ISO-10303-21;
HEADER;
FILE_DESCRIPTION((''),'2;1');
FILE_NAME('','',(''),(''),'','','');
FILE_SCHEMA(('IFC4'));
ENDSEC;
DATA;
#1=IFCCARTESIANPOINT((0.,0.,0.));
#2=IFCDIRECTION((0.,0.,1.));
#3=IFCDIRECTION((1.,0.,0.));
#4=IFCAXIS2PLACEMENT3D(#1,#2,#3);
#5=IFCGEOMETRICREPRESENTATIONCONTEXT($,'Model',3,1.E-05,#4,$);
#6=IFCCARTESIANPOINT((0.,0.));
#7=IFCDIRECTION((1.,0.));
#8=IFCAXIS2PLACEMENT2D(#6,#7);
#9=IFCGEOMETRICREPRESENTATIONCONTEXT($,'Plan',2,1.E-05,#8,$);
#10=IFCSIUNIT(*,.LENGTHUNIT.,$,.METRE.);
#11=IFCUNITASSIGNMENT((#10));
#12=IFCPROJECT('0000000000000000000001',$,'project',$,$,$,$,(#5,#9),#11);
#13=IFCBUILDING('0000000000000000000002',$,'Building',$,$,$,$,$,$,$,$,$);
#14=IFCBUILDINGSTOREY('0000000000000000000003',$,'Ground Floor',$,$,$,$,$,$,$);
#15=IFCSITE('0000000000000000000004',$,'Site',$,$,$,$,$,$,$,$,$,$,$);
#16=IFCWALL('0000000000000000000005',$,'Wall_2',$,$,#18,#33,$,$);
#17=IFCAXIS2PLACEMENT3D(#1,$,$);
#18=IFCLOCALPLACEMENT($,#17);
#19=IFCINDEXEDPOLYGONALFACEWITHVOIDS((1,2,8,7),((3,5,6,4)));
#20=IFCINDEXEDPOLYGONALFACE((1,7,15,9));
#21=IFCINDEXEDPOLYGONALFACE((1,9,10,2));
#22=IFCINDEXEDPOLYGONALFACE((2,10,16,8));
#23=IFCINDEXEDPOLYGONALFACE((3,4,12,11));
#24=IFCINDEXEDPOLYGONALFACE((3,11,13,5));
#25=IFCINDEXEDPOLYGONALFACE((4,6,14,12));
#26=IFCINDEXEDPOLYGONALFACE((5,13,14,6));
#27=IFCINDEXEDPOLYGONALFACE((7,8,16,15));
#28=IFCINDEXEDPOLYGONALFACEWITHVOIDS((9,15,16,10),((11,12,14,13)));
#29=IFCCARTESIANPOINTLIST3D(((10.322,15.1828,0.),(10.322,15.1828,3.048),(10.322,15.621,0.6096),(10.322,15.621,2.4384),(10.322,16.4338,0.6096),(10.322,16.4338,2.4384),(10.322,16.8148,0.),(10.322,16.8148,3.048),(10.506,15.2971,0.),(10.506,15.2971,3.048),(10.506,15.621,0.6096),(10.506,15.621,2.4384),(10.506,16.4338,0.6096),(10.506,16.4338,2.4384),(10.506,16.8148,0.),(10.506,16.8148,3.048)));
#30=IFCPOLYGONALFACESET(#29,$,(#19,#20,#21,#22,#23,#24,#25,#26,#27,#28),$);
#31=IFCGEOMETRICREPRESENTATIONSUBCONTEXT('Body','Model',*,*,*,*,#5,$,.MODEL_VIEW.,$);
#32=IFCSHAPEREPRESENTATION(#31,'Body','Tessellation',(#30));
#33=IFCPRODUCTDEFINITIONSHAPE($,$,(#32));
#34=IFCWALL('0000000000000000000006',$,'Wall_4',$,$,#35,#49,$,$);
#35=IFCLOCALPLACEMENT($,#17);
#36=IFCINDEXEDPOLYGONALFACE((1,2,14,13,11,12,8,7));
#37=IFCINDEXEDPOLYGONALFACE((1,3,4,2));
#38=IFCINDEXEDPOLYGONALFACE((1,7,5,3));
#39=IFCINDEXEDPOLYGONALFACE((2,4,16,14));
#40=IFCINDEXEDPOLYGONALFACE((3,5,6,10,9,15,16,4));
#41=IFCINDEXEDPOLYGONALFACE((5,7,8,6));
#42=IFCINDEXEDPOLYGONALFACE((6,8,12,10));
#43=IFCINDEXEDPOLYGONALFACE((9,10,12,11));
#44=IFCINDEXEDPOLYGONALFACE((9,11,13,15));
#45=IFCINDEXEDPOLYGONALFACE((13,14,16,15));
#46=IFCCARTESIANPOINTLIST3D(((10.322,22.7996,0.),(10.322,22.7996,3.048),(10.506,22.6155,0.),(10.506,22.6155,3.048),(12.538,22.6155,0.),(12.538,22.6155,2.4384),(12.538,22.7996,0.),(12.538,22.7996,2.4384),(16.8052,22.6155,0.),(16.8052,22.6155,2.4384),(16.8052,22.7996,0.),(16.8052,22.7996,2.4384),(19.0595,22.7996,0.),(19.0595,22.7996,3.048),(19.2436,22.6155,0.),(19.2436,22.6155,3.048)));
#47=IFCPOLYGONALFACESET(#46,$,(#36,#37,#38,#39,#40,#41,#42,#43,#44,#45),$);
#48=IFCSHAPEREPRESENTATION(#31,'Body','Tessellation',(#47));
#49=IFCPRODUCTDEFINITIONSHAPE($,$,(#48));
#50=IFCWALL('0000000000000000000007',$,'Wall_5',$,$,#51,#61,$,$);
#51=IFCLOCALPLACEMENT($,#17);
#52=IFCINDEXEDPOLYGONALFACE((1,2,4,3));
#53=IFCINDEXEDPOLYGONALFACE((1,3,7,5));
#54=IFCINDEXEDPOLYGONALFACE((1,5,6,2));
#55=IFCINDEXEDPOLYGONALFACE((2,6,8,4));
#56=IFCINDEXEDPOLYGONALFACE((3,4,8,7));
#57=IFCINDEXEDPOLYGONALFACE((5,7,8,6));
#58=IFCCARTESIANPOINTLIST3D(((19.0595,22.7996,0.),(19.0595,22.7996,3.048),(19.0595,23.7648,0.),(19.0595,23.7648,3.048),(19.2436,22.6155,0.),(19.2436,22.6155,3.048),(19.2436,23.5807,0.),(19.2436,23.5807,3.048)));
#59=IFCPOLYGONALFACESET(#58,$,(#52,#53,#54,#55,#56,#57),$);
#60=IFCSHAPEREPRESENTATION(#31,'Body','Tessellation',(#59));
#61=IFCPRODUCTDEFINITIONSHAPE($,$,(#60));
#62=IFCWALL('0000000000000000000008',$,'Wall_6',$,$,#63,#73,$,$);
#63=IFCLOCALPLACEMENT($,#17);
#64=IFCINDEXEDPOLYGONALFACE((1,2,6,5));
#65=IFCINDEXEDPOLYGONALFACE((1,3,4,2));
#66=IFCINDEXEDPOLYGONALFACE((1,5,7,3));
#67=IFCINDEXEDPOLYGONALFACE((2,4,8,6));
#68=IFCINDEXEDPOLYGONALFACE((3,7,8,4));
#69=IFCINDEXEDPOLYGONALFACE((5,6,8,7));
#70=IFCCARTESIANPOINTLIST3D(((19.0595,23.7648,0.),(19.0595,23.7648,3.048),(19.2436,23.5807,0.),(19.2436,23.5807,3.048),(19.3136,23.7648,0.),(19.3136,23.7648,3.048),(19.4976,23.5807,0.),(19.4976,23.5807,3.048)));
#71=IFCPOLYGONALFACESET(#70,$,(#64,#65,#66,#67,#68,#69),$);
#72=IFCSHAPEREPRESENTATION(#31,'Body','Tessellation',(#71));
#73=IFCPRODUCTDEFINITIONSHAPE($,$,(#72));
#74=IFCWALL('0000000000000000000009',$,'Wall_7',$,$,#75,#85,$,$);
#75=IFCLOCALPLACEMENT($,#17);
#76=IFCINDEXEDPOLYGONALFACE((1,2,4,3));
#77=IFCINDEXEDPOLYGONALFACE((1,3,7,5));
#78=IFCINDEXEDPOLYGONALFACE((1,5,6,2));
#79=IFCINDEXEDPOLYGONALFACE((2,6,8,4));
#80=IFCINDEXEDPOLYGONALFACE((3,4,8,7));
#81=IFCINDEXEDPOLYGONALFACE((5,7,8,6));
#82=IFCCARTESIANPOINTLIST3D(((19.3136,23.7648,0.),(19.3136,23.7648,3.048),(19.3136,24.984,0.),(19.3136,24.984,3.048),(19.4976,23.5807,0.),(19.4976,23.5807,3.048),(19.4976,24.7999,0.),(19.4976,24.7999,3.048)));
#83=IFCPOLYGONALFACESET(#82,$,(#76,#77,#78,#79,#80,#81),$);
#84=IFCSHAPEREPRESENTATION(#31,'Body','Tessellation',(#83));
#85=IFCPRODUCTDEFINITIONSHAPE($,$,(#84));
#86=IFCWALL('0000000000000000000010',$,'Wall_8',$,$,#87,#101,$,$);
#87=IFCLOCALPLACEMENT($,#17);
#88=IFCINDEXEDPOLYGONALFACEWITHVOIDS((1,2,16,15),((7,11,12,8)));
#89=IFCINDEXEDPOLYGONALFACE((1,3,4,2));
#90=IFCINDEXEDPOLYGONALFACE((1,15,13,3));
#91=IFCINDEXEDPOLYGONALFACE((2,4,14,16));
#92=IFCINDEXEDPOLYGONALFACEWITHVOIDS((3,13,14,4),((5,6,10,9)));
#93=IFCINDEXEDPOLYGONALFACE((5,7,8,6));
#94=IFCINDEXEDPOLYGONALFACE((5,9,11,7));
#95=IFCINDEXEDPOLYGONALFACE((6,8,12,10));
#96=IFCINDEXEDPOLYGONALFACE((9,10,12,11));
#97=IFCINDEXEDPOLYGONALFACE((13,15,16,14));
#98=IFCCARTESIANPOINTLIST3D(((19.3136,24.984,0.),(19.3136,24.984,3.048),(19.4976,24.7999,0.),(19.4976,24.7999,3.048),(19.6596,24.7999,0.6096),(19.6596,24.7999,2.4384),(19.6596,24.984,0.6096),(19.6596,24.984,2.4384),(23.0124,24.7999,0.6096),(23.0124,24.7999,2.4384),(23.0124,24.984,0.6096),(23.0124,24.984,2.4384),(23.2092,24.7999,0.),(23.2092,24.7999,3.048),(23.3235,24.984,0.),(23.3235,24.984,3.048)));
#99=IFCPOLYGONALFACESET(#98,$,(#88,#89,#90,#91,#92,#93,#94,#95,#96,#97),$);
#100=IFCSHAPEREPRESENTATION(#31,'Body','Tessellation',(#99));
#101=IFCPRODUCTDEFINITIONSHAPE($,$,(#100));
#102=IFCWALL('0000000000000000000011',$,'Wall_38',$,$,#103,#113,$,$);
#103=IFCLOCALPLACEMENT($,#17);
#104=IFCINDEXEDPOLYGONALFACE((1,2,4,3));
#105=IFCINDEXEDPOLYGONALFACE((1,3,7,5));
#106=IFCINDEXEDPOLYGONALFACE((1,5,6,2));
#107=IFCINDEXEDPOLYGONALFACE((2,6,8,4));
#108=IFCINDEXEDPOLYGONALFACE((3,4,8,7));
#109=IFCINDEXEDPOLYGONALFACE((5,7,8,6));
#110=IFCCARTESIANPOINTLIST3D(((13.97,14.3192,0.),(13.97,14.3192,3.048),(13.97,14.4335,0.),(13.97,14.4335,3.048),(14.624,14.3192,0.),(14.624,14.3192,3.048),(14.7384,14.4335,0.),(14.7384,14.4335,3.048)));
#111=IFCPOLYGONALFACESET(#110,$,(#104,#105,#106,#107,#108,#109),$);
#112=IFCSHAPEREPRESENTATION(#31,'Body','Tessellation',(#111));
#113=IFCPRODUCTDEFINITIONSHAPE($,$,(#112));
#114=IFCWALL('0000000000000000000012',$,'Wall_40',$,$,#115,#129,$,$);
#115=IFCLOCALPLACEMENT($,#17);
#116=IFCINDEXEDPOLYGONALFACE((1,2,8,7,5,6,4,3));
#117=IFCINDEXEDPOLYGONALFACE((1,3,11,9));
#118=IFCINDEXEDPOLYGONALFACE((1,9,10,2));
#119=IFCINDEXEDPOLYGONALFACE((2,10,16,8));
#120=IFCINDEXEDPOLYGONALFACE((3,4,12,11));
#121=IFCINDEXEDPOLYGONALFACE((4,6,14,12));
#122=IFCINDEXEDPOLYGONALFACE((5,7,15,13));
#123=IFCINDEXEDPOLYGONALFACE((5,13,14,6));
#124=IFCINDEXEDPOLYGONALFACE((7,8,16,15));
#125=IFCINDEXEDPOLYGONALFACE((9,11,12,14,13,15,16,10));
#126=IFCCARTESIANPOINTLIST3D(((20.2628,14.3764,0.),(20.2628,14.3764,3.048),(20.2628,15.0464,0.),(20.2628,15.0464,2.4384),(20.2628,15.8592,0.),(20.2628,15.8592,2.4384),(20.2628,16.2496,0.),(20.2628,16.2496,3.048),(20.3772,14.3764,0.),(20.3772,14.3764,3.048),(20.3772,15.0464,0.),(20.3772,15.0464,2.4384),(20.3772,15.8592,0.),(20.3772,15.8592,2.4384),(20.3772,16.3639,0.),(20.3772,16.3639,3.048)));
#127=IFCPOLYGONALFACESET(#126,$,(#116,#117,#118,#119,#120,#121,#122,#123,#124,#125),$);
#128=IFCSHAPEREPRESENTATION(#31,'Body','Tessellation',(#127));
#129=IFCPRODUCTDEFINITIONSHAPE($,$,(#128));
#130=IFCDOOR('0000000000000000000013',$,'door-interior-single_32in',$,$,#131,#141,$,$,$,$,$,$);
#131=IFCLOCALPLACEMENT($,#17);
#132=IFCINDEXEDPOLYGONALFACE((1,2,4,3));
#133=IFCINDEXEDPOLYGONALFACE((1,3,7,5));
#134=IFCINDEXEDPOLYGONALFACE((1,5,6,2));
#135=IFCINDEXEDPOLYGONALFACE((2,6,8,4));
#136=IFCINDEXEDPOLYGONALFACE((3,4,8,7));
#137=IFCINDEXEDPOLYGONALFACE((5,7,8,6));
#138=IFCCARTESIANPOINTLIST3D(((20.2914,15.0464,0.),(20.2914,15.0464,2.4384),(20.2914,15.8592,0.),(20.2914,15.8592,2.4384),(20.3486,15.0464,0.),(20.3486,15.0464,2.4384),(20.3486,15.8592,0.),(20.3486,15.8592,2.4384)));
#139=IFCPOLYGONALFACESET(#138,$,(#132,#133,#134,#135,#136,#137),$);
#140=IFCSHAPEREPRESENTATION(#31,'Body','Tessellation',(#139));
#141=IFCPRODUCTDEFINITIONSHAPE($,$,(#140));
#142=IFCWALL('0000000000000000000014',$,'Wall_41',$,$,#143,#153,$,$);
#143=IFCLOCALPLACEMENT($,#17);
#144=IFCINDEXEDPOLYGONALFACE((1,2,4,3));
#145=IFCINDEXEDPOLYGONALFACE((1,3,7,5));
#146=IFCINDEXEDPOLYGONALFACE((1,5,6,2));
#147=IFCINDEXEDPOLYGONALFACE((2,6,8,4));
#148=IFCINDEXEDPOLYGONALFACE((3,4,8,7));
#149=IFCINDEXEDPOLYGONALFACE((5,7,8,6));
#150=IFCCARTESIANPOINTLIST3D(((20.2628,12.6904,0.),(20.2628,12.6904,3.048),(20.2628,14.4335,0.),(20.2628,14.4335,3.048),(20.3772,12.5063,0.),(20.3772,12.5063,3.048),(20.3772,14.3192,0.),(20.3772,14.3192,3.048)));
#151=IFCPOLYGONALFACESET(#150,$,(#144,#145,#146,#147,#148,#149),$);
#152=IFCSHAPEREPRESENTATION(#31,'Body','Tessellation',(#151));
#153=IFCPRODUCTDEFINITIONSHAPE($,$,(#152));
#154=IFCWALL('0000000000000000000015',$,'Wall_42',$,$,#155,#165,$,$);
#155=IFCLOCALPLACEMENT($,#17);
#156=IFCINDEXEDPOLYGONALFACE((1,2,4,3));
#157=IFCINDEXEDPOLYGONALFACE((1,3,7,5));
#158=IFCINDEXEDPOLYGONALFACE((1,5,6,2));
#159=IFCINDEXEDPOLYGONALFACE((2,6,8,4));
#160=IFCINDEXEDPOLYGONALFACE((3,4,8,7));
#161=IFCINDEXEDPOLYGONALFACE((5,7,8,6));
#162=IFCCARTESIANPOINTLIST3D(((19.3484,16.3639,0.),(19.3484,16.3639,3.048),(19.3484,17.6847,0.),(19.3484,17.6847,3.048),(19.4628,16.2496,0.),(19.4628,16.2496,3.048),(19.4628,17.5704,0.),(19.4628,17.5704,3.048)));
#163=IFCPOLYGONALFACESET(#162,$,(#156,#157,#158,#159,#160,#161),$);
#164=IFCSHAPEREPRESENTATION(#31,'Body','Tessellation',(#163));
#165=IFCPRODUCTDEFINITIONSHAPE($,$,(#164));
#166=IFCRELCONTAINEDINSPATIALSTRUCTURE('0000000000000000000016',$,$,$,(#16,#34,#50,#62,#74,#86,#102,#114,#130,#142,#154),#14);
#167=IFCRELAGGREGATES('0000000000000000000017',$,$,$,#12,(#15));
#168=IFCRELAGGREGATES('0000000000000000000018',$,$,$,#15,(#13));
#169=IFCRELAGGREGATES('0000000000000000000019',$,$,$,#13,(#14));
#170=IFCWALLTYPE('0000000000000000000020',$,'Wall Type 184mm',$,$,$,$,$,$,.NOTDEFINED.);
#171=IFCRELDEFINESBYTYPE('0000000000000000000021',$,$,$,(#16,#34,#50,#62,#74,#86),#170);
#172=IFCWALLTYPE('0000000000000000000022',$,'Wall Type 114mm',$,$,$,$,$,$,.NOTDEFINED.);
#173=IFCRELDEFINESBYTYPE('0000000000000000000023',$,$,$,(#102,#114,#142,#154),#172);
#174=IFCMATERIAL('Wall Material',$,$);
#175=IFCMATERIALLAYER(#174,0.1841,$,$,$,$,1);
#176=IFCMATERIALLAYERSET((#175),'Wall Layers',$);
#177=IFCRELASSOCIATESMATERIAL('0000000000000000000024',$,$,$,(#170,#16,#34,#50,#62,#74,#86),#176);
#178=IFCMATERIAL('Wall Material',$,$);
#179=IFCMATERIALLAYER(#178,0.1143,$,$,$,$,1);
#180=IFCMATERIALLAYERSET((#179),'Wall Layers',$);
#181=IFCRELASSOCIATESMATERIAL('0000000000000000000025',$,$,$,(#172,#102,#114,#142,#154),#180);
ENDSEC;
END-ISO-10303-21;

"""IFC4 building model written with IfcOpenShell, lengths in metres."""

from ifc_helpers import new_model, si_unit, frame, origin_with_axes, origin_2d_with_axis, place, context, subcontext, project, spatial, line, indexed_curve, rectangle, outline, extrude, material, layer, layer_set, layer_usage, type_object, element, fill, save


model = new_model("IFC4")

# Units and contexts
model_context = context("Model", 3, precision=1e-05, world=origin_with_axes())
plan_context = context("Plan", 2, precision=1e-05, world=origin_2d_with_axis())
body_context = subcontext(model_context, "Body", "Model", "MODEL_VIEW")
ifc_project = project(units=[si_unit("LENGTHUNIT", "METRE")], contexts=[model_context, plan_context])

# Site, building, storey
site = spatial("IfcSite", under=ifc_project, Name="Site")
building = spatial("IfcBuilding", under=site, Name="Building")
storey = spatial("IfcBuildingStorey", under=building, Name="Ground Floor")

# Wall, opening
ifc_material_1 = material(Name="Wall Material")
ifc_layer_1 = layer(ifc_material_1, 0.1841, Priority=1)
ifc_layer_set_1 = layer_set([ifc_layer_1], Name="Wall Layers")
ifc_layer_usage_1 = layer_usage(ifc_layer_set_1, "AXIS2", "POSITIVE", -0.0921)
wall_type_1 = type_object("IfcWallType", Name="Wall Type 184mm", PredefinedType="NOTDEFINED", material=ifc_layer_set_1)
wall_1_placement = place(None, frame((10.414, 15.24, 0.0), z_axis=(0.0, 0.0, 1.0), x_axis=(0.0, 1.0, 0.0)))
wall_1 = element("IfcWall", 1, at=wall_1_placement, inside=storey, type_object=wall_type_1, material=ifc_layer_usage_1, Name="Wall_2", context=body_context, shape_type="SweptSolid", body=[
    extrude(outline(indexed_curve([(0.0571, -0.0921), (-0.0571, 0.0921), (1.5748, 0.0921), (1.5748, -0.0921)], segments=[line(1, 2, 3, 4, 1)])), origin_with_axes(), (0.0, 0.0, 1.0), 3.048),
])
opening_1_placement = place(wall_1_placement, frame((0.7874, 0.0, 0.6096), z_axis=(0.0, 0.0, 1.0), x_axis=(1.0, 0.0, 0.0)))
element("IfcOpeningElement", 2, at=opening_1_placement, cuts=wall_1, context=body_context, shape_type="SweptSolid", body=[
    extrude(rectangle(XDim=0.8128, YDim=0.5524), None, (0.0, 0.0, 1.0), 1.8288),
])

# Wall, opening
ifc_layer_usage_2 = layer_usage(ifc_layer_set_1, "AXIS2", "POSITIVE", -0.0921)
wall_2_placement = place(None, frame((10.414, 22.7076, 0.0), z_axis=(0.0, 0.0, 1.0), x_axis=(1.0, 0.0, 0.0)))
wall_2 = element("IfcWall", 3, at=wall_2_placement, inside=storey, type_object=wall_type_1, material=ifc_layer_usage_2, Name="Wall_4", context=body_context, shape_type="SweptSolid", body=[
    extrude(outline(indexed_curve([(0.0921, -0.0921), (-0.0921, 0.0921), (8.6455, 0.0921), (8.8296, -0.0921)], segments=[line(1, 2, 3, 4, 1)])), origin_with_axes(), (0.0, 0.0, 1.0), 3.048),
])
opening_2_placement = place(wall_2_placement, frame((4.2576, 0.0, 0.0), z_axis=(0.0, 0.0, 1.0), x_axis=(1.0, 0.0, 0.0)))
element("IfcOpeningElement", 4, at=opening_2_placement, cuts=wall_2, context=body_context, shape_type="SweptSolid", body=[
    extrude(rectangle(XDim=4.2672, YDim=0.5524), None, (0.0, 0.0, 1.0), 2.4384),
])

# Walls
ifc_layer_usage_3 = layer_usage(ifc_layer_set_1, "AXIS2", "POSITIVE", -0.0921)
wall_3_placement = place(None, frame((19.1516, 22.7076, 0.0), z_axis=(0.0, 0.0, 1.0), x_axis=(0.0, 1.0, 0.0)))
element("IfcWall", 5, at=wall_3_placement, inside=storey, type_object=wall_type_1, material=ifc_layer_usage_3, Name="Wall_5", context=body_context, shape_type="SweptSolid", body=[
    extrude(outline(indexed_curve([(-0.0921, -0.0921), (0.0921, 0.0921), (1.0572, 0.0921), (0.8731, -0.0921)], segments=[line(1, 2, 3, 4, 1)])), origin_with_axes(), (0.0, 0.0, 1.0), 3.048),
])
ifc_layer_usage_4 = layer_usage(ifc_layer_set_1, "AXIS2", "POSITIVE", -0.0921)
wall_4_placement = place(None, frame((19.1516, 23.6728, 0.0), z_axis=(0.0, 0.0, 1.0), x_axis=(1.0, 0.0, 0.0)))
element("IfcWall", 6, at=wall_4_placement, inside=storey, type_object=wall_type_1, material=ifc_layer_usage_4, Name="Wall_6", context=body_context, shape_type="SweptSolid", body=[
    extrude(outline(indexed_curve([(0.0921, -0.0921), (-0.0921, 0.0921), (0.162, 0.0921), (0.3461, -0.0921)], segments=[line(1, 2, 3, 4, 1)])), origin_with_axes(), (0.0, 0.0, 1.0), 3.048),
])
ifc_layer_usage_5 = layer_usage(ifc_layer_set_1, "AXIS2", "POSITIVE", -0.0921)
wall_5_placement = place(None, frame((19.4056, 23.6728, 0.0), z_axis=(0.0, 0.0, 1.0), x_axis=(0.0, 1.0, 0.0)))
element("IfcWall", 7, at=wall_5_placement, inside=storey, type_object=wall_type_1, material=ifc_layer_usage_5, Name="Wall_7", context=body_context, shape_type="SweptSolid", body=[
    extrude(outline(indexed_curve([(-0.0921, -0.0921), (0.0921, 0.0921), (1.3113, 0.0921), (1.1272, -0.0921)], segments=[line(1, 2, 3, 4, 1)])), origin_with_axes(), (0.0, 0.0, 1.0), 3.048),
])

# Wall, opening
ifc_layer_usage_6 = layer_usage(ifc_layer_set_1, "AXIS2", "POSITIVE", -0.0921)
wall_6_placement = place(None, frame((19.4056, 24.892, 0.0), z_axis=(0.0, 0.0, 1.0), x_axis=(1.0, 0.0, 0.0)))
wall_6 = element("IfcWall", 8, at=wall_6_placement, inside=storey, type_object=wall_type_1, material=ifc_layer_usage_6, Name="Wall_8", context=body_context, shape_type="SweptSolid", body=[
    extrude(outline(indexed_curve([(0.0921, -0.0921), (-0.0921, 0.0921), (3.9179, 0.0921), (3.8036, -0.0921)], segments=[line(1, 2, 3, 4, 1)])), origin_with_axes(), (0.0, 0.0, 1.0), 3.048),
])
opening_3_placement = place(wall_6_placement, frame((1.9304, 0.0, 0.6096), z_axis=(0.0, 0.0, 1.0), x_axis=(1.0, 0.0, 0.0)))
element("IfcOpeningElement", 9, at=opening_3_placement, cuts=wall_6, context=body_context, shape_type="SweptSolid", body=[
    extrude(rectangle(XDim=3.3528, YDim=0.5524), None, (0.0, 0.0, 1.0), 1.8288),
])

# Wall
ifc_material_2 = material(Name="Wall Material")
ifc_layer_2 = layer(ifc_material_2, 0.1143, Priority=1)
ifc_layer_set_2 = layer_set([ifc_layer_2], Name="Wall Layers")
ifc_layer_usage_7 = layer_usage(ifc_layer_set_2, "AXIS2", "POSITIVE", -0.0571)
wall_type_2 = type_object("IfcWallType", Name="Wall Type 114mm", PredefinedType="NOTDEFINED", material=ifc_layer_set_2)
wall_7_placement = place(None, frame((14.6812, 14.3764, 0.0), z_axis=(0.0, 0.0, 1.0), x_axis=(-1.0, 0.0, 0.0)))
element("IfcWall", 10, at=wall_7_placement, inside=storey, type_object=wall_type_2, material=ifc_layer_usage_7, Name="Wall_38", context=body_context, shape_type="SweptSolid", body=[
    extrude(outline(indexed_curve([(-0.0571, -0.0571), (0.0571, 0.0571), (0.7112, 0.0571), (0.7112, -0.0571)], segments=[line(1, 2, 3, 4, 1)])), origin_with_axes(), (0.0, 0.0, 1.0), 3.048),
])

# Wall, opening, door
ifc_layer_usage_8 = layer_usage(ifc_layer_set_2, "AXIS2", "POSITIVE", -0.0571)
wall_8_placement = place(None, frame((20.32, 16.3068, 0.0), z_axis=(0.0, 0.0, 1.0), x_axis=(0.0, -1.0, 0.0)))
wall_8 = element("IfcWall", 11, at=wall_8_placement, inside=storey, type_object=wall_type_2, material=ifc_layer_usage_8, Name="Wall_40", context=body_context, shape_type="SweptSolid", body=[
    extrude(outline(indexed_curve([(0.0571, -0.0571), (-0.0571, 0.0571), (1.9304, 0.0571), (1.9304, -0.0571)], segments=[line(1, 2, 3, 4, 1)])), origin_with_axes(), (0.0, 0.0, 1.0), 3.048),
])
opening_4_placement = place(wall_8_placement, frame((0.854, 0.0, 0.0), z_axis=(0.0, 0.0, 1.0), x_axis=(1.0, 0.0, 0.0)))
opening_4 = element("IfcOpeningElement", 12, at=opening_4_placement, cuts=wall_8, context=body_context, shape_type="SweptSolid", body=[
    extrude(rectangle(XDim=0.8128, YDim=0.5), None, (0.0, 0.0, 1.0), 2.4384),
])
door_1_placement = place(None, frame((20.32, 15.4528, 0.0), z_axis=(0.0, 0.0, 1.0), x_axis=(0.0, 1.0, 0.0)))
door_1 = element("IfcDoor", 13, at=door_1_placement, inside=storey, Name="door-interior-single_32in", context=body_context, shape_type="SweptSolid", body=[
    extrude(rectangle(XDim=0.8128, YDim=0.0571), None, (0.0, 0.0, 1.0), 2.4384),
])
fill(opening_4, door_1)

# Walls
ifc_layer_usage_9 = layer_usage(ifc_layer_set_2, "AXIS2", "POSITIVE", -0.0571)
wall_9_placement = place(None, frame((20.32, 14.3764, 0.0), z_axis=(0.0, 0.0, 1.0), x_axis=(0.0, -1.0, 0.0)))
element("IfcWall", 14, at=wall_9_placement, inside=storey, type_object=wall_type_2, material=ifc_layer_usage_9, Name="Wall_41", context=body_context, shape_type="SweptSolid", body=[
    extrude(outline(indexed_curve([(-0.0572, -0.0571), (0.0572, 0.0571), (1.8701, 0.0571), (1.686, -0.0571)], segments=[line(1, 2, 3, 4, 1)])), origin_with_axes(), (0.0, 0.0, 1.0), 3.048),
])
ifc_layer_usage_10 = layer_usage(ifc_layer_set_2, "AXIS2", "POSITIVE", -0.0571)
wall_10_placement = place(None, frame((19.4056, 16.3068, 0.0), z_axis=(0.0, 0.0, 1.0), x_axis=(0.0, 1.0, 0.0)))
element("IfcWall", 15, at=wall_10_placement, inside=storey, type_object=wall_type_2, material=ifc_layer_usage_10, Name="Wall_42", context=body_context, shape_type="SweptSolid", body=[
    extrude(outline(indexed_curve([(-0.0572, -0.0571), (0.0572, 0.0571), (1.378, 0.0571), (1.2637, -0.0571)], segments=[line(1, 2, 3, 4, 1)])), origin_with_axes(), (0.0, 0.0, 1.0), 3.048),
])

save(model, "model.ifc")
